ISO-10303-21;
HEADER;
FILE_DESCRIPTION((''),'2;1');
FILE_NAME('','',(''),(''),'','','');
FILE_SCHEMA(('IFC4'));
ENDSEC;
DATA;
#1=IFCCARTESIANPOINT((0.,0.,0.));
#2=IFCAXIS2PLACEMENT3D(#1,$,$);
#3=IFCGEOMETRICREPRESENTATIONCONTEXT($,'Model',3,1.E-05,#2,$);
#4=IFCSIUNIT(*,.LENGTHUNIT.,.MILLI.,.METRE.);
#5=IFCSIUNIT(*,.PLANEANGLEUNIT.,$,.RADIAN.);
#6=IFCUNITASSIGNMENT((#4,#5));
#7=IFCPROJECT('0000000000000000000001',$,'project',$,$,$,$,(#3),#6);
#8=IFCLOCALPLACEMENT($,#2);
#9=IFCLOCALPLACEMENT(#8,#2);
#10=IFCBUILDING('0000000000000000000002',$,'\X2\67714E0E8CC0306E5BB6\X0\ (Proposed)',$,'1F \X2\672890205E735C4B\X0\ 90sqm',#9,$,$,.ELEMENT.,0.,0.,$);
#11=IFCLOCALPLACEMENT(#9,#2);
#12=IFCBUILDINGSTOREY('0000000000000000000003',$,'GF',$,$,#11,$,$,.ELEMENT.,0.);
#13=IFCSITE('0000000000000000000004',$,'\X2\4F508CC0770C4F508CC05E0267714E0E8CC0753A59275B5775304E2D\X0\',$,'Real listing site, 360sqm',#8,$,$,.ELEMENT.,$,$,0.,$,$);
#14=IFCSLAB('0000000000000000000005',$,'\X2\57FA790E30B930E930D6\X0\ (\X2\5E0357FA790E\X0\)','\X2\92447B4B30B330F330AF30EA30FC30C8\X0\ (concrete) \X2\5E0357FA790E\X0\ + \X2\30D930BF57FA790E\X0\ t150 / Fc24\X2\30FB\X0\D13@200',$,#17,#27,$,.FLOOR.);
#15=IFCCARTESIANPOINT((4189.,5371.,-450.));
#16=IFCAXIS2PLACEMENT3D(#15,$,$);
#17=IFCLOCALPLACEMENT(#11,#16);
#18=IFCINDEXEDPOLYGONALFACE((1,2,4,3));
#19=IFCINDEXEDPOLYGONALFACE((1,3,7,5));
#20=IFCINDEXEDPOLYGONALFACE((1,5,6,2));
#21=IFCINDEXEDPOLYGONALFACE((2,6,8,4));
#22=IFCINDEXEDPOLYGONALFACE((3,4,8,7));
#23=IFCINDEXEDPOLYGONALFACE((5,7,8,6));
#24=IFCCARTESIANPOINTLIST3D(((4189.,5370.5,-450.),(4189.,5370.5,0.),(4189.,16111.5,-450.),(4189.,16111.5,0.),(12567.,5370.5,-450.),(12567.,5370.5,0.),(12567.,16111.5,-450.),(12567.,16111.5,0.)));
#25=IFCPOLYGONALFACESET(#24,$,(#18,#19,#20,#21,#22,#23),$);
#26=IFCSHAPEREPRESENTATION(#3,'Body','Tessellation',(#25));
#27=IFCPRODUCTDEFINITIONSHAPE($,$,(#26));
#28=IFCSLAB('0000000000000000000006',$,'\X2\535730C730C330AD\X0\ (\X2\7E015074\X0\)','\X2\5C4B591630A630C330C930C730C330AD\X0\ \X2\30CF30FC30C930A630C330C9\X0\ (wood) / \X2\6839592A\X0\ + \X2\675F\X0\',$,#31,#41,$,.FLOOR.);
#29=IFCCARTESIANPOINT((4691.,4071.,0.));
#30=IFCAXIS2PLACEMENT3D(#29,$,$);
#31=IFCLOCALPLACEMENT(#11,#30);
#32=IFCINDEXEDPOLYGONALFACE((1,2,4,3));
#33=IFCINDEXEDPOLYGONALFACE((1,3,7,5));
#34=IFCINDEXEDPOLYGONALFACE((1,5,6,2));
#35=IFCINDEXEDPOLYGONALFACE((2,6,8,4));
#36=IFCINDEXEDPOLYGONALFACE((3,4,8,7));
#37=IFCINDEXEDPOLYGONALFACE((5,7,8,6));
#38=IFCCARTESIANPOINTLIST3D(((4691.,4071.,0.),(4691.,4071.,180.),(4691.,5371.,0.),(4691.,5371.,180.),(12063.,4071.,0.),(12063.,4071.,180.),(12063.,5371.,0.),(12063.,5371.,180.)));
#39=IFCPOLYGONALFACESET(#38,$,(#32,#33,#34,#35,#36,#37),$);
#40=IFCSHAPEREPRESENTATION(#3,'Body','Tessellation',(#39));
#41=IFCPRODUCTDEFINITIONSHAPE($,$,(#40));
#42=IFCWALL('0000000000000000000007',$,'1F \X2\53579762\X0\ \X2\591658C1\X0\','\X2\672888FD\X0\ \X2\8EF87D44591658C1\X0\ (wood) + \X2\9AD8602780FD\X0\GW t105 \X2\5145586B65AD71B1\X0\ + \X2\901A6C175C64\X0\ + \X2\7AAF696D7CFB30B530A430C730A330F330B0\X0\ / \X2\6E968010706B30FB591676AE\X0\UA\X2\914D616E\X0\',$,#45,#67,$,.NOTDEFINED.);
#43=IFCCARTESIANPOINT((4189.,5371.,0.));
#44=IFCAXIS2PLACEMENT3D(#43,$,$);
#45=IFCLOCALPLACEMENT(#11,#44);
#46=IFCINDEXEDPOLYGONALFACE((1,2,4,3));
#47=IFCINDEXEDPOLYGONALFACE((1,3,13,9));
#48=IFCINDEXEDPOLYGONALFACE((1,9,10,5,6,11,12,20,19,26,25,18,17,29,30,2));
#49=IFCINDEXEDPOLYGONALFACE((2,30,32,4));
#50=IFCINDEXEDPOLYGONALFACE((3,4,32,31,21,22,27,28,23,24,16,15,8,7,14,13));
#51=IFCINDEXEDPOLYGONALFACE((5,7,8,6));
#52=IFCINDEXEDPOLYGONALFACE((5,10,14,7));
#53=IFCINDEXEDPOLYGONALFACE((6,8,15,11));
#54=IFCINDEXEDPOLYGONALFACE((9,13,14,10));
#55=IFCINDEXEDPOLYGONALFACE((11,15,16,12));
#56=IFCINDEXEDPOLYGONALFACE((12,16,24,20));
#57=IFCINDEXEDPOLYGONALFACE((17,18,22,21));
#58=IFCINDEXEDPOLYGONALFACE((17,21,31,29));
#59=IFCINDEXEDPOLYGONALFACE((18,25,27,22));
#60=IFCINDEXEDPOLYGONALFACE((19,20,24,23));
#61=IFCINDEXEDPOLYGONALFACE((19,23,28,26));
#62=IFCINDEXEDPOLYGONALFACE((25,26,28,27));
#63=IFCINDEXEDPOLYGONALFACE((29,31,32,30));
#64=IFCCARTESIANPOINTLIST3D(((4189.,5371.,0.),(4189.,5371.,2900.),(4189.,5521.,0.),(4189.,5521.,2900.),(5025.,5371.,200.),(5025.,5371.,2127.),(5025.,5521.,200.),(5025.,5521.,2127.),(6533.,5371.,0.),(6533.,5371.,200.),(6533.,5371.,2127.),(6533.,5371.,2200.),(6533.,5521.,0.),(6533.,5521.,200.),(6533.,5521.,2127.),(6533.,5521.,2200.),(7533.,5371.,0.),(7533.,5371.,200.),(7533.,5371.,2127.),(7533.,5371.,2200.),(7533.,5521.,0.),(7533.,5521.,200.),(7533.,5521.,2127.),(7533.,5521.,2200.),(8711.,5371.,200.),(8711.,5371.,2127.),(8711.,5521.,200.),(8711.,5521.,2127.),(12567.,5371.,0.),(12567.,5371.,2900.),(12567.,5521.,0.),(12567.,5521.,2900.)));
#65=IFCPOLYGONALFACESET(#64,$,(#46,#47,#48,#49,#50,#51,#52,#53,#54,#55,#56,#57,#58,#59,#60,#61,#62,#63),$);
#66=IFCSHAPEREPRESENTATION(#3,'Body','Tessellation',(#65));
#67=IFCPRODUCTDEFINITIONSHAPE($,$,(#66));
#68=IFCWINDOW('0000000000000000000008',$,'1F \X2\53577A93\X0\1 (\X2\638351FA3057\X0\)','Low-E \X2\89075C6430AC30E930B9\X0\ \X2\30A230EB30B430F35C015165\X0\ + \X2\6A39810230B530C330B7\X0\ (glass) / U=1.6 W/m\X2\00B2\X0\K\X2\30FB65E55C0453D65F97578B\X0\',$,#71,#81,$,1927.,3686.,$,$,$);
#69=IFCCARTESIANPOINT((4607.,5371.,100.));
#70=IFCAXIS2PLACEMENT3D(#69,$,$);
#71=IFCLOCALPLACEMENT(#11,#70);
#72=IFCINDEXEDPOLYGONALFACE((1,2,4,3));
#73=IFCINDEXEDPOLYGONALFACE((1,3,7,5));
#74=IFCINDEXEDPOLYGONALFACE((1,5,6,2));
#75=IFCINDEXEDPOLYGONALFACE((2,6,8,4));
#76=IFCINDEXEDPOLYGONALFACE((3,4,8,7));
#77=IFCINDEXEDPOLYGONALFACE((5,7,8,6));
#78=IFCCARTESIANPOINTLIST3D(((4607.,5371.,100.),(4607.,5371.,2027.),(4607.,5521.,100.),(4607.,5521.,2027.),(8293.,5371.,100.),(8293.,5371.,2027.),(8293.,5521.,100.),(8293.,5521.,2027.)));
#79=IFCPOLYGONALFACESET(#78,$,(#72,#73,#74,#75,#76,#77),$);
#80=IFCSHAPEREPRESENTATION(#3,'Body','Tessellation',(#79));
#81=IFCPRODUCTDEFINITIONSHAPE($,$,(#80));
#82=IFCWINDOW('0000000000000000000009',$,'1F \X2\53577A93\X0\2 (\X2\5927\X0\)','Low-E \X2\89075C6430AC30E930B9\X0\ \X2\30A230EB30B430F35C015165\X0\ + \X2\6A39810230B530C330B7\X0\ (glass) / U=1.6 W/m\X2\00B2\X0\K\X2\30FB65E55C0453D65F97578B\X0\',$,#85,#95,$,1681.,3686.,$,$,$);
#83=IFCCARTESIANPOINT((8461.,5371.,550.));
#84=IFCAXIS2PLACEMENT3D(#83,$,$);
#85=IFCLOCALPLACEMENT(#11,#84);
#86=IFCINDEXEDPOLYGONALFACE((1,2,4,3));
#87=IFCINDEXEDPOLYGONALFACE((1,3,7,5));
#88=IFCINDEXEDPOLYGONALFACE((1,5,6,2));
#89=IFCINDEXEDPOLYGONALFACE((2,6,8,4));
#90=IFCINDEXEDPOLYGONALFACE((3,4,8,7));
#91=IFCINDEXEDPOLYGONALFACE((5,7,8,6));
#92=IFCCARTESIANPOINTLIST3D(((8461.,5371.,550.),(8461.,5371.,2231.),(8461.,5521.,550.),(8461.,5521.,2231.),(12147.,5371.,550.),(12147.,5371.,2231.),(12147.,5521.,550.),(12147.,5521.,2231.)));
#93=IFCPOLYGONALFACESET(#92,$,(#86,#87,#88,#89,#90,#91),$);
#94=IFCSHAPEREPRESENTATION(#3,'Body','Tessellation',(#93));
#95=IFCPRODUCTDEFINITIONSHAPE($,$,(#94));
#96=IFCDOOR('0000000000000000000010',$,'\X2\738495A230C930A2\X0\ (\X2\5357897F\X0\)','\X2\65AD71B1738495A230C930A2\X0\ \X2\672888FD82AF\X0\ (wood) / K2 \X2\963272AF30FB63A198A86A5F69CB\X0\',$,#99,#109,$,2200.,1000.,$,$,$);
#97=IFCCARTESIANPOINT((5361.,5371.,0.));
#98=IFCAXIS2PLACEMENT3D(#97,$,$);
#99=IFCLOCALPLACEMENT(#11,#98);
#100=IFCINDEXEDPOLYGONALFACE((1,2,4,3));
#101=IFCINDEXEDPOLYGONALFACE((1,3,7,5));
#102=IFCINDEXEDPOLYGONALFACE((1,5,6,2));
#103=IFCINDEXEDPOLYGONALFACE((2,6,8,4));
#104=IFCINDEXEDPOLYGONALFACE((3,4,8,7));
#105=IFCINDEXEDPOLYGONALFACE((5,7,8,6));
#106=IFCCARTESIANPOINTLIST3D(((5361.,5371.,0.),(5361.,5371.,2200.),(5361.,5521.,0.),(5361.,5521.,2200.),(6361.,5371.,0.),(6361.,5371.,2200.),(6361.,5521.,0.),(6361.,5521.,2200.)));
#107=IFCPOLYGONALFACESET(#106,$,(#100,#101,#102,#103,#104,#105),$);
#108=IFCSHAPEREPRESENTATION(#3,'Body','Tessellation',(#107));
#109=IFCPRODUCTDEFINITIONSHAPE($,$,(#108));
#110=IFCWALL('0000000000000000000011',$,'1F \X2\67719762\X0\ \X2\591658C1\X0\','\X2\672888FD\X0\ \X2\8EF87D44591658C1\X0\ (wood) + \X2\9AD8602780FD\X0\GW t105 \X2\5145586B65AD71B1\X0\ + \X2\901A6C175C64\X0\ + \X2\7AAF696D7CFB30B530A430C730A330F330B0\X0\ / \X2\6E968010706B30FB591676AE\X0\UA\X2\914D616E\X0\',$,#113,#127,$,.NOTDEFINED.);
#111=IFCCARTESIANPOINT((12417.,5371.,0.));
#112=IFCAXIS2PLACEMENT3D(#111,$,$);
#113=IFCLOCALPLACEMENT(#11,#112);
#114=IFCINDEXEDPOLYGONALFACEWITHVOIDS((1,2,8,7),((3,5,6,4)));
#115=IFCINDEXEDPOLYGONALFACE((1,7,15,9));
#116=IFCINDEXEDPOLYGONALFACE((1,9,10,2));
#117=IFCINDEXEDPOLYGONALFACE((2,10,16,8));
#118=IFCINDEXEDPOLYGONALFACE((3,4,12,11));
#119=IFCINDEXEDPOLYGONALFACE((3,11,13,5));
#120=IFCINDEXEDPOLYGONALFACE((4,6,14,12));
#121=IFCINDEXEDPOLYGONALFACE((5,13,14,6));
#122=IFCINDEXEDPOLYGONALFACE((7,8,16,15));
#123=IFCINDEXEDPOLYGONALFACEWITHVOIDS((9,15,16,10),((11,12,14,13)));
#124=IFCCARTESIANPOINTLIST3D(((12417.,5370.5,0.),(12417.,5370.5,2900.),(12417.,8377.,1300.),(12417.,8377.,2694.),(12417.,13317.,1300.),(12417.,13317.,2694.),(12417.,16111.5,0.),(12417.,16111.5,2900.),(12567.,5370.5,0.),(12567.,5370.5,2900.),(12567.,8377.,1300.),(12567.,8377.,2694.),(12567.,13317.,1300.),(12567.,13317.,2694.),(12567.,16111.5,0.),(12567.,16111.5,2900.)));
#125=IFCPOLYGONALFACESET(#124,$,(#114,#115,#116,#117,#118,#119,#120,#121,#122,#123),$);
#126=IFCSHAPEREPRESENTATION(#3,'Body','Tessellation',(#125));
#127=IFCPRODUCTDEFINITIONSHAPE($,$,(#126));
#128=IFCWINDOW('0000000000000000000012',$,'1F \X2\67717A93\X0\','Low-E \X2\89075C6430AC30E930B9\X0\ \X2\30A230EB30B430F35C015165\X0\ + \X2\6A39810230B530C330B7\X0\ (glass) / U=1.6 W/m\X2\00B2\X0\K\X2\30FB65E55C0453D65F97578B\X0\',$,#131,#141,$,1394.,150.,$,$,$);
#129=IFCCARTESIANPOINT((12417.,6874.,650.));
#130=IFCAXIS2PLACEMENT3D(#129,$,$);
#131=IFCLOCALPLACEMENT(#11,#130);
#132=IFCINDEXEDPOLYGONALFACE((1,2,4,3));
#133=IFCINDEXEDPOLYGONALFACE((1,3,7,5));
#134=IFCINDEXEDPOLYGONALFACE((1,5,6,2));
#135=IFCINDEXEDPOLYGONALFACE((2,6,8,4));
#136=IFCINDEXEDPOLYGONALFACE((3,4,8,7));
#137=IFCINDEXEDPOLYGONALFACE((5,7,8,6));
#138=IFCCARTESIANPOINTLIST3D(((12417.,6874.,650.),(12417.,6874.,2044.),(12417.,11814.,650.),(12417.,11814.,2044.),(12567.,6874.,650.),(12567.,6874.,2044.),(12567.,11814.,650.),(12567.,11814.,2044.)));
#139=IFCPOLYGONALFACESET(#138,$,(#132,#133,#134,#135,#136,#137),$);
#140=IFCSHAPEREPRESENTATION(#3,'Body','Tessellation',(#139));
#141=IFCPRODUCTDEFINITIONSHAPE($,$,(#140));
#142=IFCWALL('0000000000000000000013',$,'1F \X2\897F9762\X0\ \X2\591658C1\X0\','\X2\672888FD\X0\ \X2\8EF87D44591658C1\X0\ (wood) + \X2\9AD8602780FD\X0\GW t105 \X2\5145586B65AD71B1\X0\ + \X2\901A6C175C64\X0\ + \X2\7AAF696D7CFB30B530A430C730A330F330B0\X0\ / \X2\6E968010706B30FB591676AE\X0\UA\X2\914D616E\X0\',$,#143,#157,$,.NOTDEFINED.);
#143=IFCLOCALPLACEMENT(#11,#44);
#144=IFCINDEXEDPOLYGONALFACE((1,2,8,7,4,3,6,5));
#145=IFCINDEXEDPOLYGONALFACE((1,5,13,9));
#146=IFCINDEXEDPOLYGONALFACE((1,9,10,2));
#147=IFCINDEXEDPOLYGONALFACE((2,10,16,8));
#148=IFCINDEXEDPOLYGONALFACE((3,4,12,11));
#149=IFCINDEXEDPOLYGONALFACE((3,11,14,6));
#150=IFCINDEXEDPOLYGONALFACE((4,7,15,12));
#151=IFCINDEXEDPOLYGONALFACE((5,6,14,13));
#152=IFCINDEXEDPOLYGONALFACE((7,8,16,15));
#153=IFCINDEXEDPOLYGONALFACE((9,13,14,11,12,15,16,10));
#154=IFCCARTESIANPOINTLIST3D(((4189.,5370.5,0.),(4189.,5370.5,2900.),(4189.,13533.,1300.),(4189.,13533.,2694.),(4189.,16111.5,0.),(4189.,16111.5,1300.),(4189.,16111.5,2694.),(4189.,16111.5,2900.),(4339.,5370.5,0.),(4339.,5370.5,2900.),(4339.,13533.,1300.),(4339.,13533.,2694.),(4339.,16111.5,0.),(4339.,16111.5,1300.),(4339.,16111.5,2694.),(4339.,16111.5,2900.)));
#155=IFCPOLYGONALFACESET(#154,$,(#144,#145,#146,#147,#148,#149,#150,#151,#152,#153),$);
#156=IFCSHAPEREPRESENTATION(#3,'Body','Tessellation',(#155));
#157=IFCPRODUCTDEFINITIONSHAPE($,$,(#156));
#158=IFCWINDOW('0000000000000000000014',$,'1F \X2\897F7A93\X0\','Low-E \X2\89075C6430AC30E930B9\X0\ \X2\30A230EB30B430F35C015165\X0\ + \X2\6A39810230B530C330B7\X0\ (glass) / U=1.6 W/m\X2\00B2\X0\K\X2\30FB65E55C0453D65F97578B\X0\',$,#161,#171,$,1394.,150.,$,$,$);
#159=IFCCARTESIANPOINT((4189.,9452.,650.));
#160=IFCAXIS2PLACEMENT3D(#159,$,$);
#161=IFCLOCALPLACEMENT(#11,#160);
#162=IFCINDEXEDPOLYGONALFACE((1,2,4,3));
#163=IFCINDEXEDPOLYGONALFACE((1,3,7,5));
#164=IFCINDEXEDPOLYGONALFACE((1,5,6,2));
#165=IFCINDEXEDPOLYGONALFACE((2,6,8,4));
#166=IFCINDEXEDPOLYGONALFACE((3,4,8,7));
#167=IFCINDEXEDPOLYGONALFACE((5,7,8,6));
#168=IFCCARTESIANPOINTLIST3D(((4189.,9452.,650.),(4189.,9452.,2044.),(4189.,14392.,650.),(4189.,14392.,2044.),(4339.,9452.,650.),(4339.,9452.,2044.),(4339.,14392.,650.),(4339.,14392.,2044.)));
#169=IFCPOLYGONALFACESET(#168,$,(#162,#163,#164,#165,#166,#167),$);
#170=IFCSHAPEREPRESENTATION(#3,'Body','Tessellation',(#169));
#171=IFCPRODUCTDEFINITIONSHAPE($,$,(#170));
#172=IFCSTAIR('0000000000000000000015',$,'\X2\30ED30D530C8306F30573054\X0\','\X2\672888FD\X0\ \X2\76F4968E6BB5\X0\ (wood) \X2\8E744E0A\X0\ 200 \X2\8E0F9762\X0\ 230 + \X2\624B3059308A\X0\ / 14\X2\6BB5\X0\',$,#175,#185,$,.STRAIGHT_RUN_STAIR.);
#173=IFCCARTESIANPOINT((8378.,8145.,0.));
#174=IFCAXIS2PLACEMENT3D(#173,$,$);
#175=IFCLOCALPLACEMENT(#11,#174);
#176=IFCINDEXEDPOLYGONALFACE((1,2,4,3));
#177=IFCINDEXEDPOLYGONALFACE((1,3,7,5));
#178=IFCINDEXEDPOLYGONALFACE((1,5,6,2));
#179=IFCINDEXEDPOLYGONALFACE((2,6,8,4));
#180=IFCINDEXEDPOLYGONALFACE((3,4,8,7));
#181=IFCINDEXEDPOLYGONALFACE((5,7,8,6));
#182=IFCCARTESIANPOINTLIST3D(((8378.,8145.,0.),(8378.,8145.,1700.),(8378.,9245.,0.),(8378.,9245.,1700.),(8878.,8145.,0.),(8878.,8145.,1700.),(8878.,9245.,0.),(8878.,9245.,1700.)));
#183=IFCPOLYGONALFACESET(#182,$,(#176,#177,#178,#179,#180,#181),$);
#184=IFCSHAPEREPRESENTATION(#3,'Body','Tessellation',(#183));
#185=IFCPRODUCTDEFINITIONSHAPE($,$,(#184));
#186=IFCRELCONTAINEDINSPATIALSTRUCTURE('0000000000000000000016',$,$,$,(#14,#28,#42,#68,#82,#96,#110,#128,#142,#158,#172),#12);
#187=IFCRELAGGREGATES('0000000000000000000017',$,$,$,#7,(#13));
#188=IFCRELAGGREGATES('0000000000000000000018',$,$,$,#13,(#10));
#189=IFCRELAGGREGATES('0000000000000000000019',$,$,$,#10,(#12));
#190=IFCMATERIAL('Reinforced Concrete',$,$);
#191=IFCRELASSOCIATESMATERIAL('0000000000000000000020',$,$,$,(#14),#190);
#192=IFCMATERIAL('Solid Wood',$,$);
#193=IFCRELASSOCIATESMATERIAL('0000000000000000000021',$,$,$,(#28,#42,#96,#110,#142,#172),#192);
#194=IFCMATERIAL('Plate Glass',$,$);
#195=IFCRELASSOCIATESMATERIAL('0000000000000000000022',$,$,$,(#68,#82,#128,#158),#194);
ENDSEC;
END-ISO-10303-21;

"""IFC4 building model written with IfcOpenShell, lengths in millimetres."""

from ifc_helpers import new_model, si_unit, frame, frame_2d, origin, place, context, project, spatial, rectangle, extrude, material, element, fill, save


model = new_model("IFC4")

# Units and contexts
model_context = context("Model", 3, precision=1e-05, world=origin())
ifc_project = project(units=[si_unit("LENGTHUNIT", "METRE", prefix="MILLI"), si_unit("PLANEANGLEUNIT", "RADIAN")], contexts=[model_context])

# Site, building, storey
site_placement = place(None, origin())
site = spatial("IfcSite", under=ifc_project, at=site_placement, Name="佐賀県佐賀市東与賀町大字田中", ObjectType="Real listing site, 360sqm", CompositionType="ELEMENT", RefElevation=0.0)
building_placement = place(site_placement, origin())
building = spatial("IfcBuilding", under=site, at=building_placement, Name="東与賀の家 (Proposed)", ObjectType="1F 木造平屋 90sqm", CompositionType="ELEMENT", ElevationOfRefHeight=0.0, ElevationOfTerrain=0.0)
storey_placement = place(building_placement, origin())
storey = spatial("IfcBuildingStorey", under=building, at=storey_placement, Name="GF", CompositionType="ELEMENT", Elevation=0.0)

# Slabs
ifc_material_1 = material(Name="Reinforced Concrete")
slab_1_placement = place(storey_placement, frame((4189.0, 5371.0, -450.0)))
element("IfcSlab", 1, at=slab_1_placement, inside=storey, material=ifc_material_1, Name="基礎スラブ (布基礎)", Description="鉄筋コンクリート (concrete) 布基礎 + ベタ基礎 t150 / Fc24・D13@200", PredefinedType="FLOOR", context=model_context, shape_type="SweptSolid", body=[
    extrude(rectangle(XDim=8378.0, YDim=10741.0, at=frame_2d((4189.0, 5370.0))), frame((4189.0, 5371.0, -450.0)), (0.0, 0.0, 1.0), 450.0),
])
ifc_material_2 = material(Name="Solid Wood")
slab_2_placement = place(storey_placement, frame((4691.0, 4071.0, 0.0)))
element("IfcSlab", 2, at=slab_2_placement, inside=storey, material=ifc_material_2, Name="南デッキ (縁側)", Description="屋外ウッドデッキ ハードウッド (wood) / 根太 + 束", PredefinedType="FLOOR", context=model_context, shape_type="SweptSolid", body=[
    extrude(rectangle(XDim=7372.0, YDim=1300.0, at=frame_2d((3686.0, 650.0))), frame((4691.0, 4071.0, 0.0)), (0.0, 0.0, 1.0), 180.0),
])

# Wall, openings, windows, door
wall_1_placement = place(storey_placement, frame((4189.0, 5371.0, 0.0)))
wall_1 = element("IfcWall", 3, at=wall_1_placement, inside=storey, material=ifc_material_2, Name="1F 南面 外壁", Description="木製 軸組外壁 (wood) + 高性能GW t105 充填断熱 + 通気層 + 窯業系サイディング / 準耐火・外皮UA配慮", PredefinedType="NOTDEFINED", context=model_context, shape_type="SweptSolid", body=[
    extrude(rectangle(XDim=8378.0, YDim=150.0, at=frame_2d((4189.0, 75.0))), frame((4189.0, 5371.0, 0.0)), (0.0, 0.0, 1.0), 2900.0),
])
opening_1_placement = place(storey_placement, frame((4607.0, 5371.0, 100.0)))
opening_1 = element("IfcOpeningElement", 4, at=opening_1_placement, cuts=wall_1, PredefinedType="NOTDEFINED", context=model_context, shape_type="SweptSolid", body=[
    extrude(rectangle(XDim=3686.0, YDim=150.0, at=frame_2d((1843.0, 75.0))), frame((4607.0, 5371.0, 100.0)), (0.0, 0.0, 1.0), 1927.0),
])
opening_2_placement = place(storey_placement, frame((8461.0, 5371.0, 550.0)))
opening_2 = element("IfcOpeningElement", 5, at=opening_2_placement, cuts=wall_1, PredefinedType="NOTDEFINED", context=model_context, shape_type="SweptSolid", body=[
    extrude(rectangle(XDim=3686.0, YDim=150.0, at=frame_2d((1843.0, 75.0))), frame((8461.0, 5371.0, 550.0)), (0.0, 0.0, 1.0), 1681.0),
])
opening_3_placement = place(storey_placement, frame((5361.0, 5371.0, 0.0)))
opening_3 = element("IfcOpeningElement", 6, at=opening_3_placement, cuts=wall_1, PredefinedType="NOTDEFINED", context=model_context, shape_type="SweptSolid", body=[
    extrude(rectangle(XDim=1000.0, YDim=150.0, at=frame_2d((500.0, 75.0))), frame((5361.0, 5371.0, 0.0)), (0.0, 0.0, 1.0), 2200.0),
])
ifc_material_3 = material(Name="Plate Glass")
window_1_placement = place(storey_placement, frame((4607.0, 5371.0, 100.0)))
window_1 = element("IfcWindow", 7, at=window_1_placement, inside=storey, material=ifc_material_3, Name="1F 南窓1 (掃出し)", Description="Low-E 複層ガラス アルゴン封入 + 樹脂サッシ (glass) / U=1.6 W/m²K・日射取得型", OverallHeight=1927.0, OverallWidth=3686.0, context=model_context, shape_type="SweptSolid", body=[
    extrude(rectangle(XDim=3686.0, YDim=150.0, at=frame_2d((1843.0, 75.0))), frame((4607.0, 5371.0, 100.0)), (0.0, 0.0, 1.0), 1927.0),
])
fill(opening_1, window_1)
window_2_placement = place(storey_placement, frame((8461.0, 5371.0, 550.0)))
window_2 = element("IfcWindow", 8, at=window_2_placement, inside=storey, material=ifc_material_3, Name="1F 南窓2 (大)", Description="Low-E 複層ガラス アルゴン封入 + 樹脂サッシ (glass) / U=1.6 W/m²K・日射取得型", OverallHeight=1681.0, OverallWidth=3686.0, context=model_context, shape_type="SweptSolid", body=[
    extrude(rectangle(XDim=3686.0, YDim=150.0, at=frame_2d((1843.0, 75.0))), frame((8461.0, 5371.0, 550.0)), (0.0, 0.0, 1.0), 1681.0),
])
fill(opening_2, window_2)
door_placement = place(storey_placement, frame((5361.0, 5371.0, 0.0)))
door = element("IfcDoor", 9, at=door_placement, inside=storey, material=ifc_material_2, Name="玄関ドア (南西)", Description="断熱玄関ドア 木製芯 (wood) / K2 防犯・採風機構", OverallHeight=2200.0, OverallWidth=1000.0, context=model_context, shape_type="SweptSolid", body=[
    extrude(rectangle(XDim=1000.0, YDim=150.0, at=frame_2d((500.0, 75.0))), frame((5361.0, 5371.0, 0.0)), (0.0, 0.0, 1.0), 2200.0),
])
fill(opening_3, door)

# Walls, openings, windows
wall_2_placement = place(storey_placement, frame((12417.0, 5371.0, 0.0)))
wall_2 = element("IfcWall", 10, at=wall_2_placement, inside=storey, material=ifc_material_2, Name="1F 東面 外壁", Description="木製 軸組外壁 (wood) + 高性能GW t105 充填断熱 + 通気層 + 窯業系サイディング / 準耐火・外皮UA配慮", PredefinedType="NOTDEFINED", context=model_context, shape_type="SweptSolid", body=[
    extrude(rectangle(XDim=150.0, YDim=10741.0, at=frame_2d((75.0, 5370.0))), frame((12417.0, 5371.0, 0.0)), (0.0, 0.0, 1.0), 2900.0),
])
opening_4_placement = place(storey_placement, frame((12417.0, 6874.0, 650.0)))
opening_4 = element("IfcOpeningElement", 11, at=opening_4_placement, cuts=wall_2, PredefinedType="NOTDEFINED", context=model_context, shape_type="SweptSolid", body=[
    extrude(rectangle(XDim=150.0, YDim=4940.0, at=frame_2d((75.0, 2470.0))), frame((12417.0, 6874.0, 650.0)), (0.0, 0.0, 1.0), 1394.0),
])
window_3_placement = place(storey_placement, frame((12417.0, 6874.0, 650.0)))
window_3 = element("IfcWindow", 12, at=window_3_placement, inside=storey, material=ifc_material_3, Name="1F 東窓", Description="Low-E 複層ガラス アルゴン封入 + 樹脂サッシ (glass) / U=1.6 W/m²K・日射取得型", OverallHeight=1394.0, OverallWidth=150.0, context=model_context, shape_type="SweptSolid", body=[
    extrude(rectangle(XDim=150.0, YDim=4940.0, at=frame_2d((75.0, 2470.0))), frame((12417.0, 6874.0, 650.0)), (0.0, 0.0, 1.0), 1394.0),
])
fill(opening_4, window_3)
wall_3_placement = place(storey_placement, frame((4189.0, 5371.0, 0.0)))
wall_3 = element("IfcWall", 13, at=wall_3_placement, inside=storey, material=ifc_material_2, Name="1F 西面 外壁", Description="木製 軸組外壁 (wood) + 高性能GW t105 充填断熱 + 通気層 + 窯業系サイディング / 準耐火・外皮UA配慮", PredefinedType="NOTDEFINED", context=model_context, shape_type="SweptSolid", body=[
    extrude(rectangle(XDim=150.0, YDim=10741.0, at=frame_2d((75.0, 5370.0))), frame((4189.0, 5371.0, 0.0)), (0.0, 0.0, 1.0), 2900.0),
])
opening_5_placement = place(storey_placement, frame((4189.0, 9452.0, 650.0)))
opening_5 = element("IfcOpeningElement", 14, at=opening_5_placement, cuts=wall_3, PredefinedType="NOTDEFINED", context=model_context, shape_type="SweptSolid", body=[
    extrude(rectangle(XDim=150.0, YDim=4940.0, at=frame_2d((75.0, 2470.0))), frame((4189.0, 9452.0, 650.0)), (0.0, 0.0, 1.0), 1394.0),
])
window_4_placement = place(storey_placement, frame((4189.0, 9452.0, 650.0)))
window_4 = element("IfcWindow", 15, at=window_4_placement, inside=storey, material=ifc_material_3, Name="1F 西窓", Description="Low-E 複層ガラス アルゴン封入 + 樹脂サッシ (glass) / U=1.6 W/m²K・日射取得型", OverallHeight=1394.0, OverallWidth=150.0, context=model_context, shape_type="SweptSolid", body=[
    extrude(rectangle(XDim=150.0, YDim=4940.0, at=frame_2d((75.0, 2470.0))), frame((4189.0, 9452.0, 650.0)), (0.0, 0.0, 1.0), 1394.0),
])
fill(opening_5, window_4)

# Stair
stair_placement = place(storey_placement, frame((8378.0, 8145.0, 0.0)))
element("IfcStair", 16, at=stair_placement, inside=storey, material=ifc_material_2, Name="ロフトはしご", Description="木製 直階段 (wood) 蹴上 200 踏面 230 + 手すり / 14段", PredefinedType="STRAIGHT_RUN_STAIR", context=model_context, shape_type="SweptSolid", body=[
    extrude(rectangle(XDim=500.0, YDim=1100.0, at=frame_2d((250.0, 550.0))), frame((8378.0, 8145.0, 0.0)), (0.0, 0.0, 1.0), 1700.0),
])

save(model, "model.ifc")
